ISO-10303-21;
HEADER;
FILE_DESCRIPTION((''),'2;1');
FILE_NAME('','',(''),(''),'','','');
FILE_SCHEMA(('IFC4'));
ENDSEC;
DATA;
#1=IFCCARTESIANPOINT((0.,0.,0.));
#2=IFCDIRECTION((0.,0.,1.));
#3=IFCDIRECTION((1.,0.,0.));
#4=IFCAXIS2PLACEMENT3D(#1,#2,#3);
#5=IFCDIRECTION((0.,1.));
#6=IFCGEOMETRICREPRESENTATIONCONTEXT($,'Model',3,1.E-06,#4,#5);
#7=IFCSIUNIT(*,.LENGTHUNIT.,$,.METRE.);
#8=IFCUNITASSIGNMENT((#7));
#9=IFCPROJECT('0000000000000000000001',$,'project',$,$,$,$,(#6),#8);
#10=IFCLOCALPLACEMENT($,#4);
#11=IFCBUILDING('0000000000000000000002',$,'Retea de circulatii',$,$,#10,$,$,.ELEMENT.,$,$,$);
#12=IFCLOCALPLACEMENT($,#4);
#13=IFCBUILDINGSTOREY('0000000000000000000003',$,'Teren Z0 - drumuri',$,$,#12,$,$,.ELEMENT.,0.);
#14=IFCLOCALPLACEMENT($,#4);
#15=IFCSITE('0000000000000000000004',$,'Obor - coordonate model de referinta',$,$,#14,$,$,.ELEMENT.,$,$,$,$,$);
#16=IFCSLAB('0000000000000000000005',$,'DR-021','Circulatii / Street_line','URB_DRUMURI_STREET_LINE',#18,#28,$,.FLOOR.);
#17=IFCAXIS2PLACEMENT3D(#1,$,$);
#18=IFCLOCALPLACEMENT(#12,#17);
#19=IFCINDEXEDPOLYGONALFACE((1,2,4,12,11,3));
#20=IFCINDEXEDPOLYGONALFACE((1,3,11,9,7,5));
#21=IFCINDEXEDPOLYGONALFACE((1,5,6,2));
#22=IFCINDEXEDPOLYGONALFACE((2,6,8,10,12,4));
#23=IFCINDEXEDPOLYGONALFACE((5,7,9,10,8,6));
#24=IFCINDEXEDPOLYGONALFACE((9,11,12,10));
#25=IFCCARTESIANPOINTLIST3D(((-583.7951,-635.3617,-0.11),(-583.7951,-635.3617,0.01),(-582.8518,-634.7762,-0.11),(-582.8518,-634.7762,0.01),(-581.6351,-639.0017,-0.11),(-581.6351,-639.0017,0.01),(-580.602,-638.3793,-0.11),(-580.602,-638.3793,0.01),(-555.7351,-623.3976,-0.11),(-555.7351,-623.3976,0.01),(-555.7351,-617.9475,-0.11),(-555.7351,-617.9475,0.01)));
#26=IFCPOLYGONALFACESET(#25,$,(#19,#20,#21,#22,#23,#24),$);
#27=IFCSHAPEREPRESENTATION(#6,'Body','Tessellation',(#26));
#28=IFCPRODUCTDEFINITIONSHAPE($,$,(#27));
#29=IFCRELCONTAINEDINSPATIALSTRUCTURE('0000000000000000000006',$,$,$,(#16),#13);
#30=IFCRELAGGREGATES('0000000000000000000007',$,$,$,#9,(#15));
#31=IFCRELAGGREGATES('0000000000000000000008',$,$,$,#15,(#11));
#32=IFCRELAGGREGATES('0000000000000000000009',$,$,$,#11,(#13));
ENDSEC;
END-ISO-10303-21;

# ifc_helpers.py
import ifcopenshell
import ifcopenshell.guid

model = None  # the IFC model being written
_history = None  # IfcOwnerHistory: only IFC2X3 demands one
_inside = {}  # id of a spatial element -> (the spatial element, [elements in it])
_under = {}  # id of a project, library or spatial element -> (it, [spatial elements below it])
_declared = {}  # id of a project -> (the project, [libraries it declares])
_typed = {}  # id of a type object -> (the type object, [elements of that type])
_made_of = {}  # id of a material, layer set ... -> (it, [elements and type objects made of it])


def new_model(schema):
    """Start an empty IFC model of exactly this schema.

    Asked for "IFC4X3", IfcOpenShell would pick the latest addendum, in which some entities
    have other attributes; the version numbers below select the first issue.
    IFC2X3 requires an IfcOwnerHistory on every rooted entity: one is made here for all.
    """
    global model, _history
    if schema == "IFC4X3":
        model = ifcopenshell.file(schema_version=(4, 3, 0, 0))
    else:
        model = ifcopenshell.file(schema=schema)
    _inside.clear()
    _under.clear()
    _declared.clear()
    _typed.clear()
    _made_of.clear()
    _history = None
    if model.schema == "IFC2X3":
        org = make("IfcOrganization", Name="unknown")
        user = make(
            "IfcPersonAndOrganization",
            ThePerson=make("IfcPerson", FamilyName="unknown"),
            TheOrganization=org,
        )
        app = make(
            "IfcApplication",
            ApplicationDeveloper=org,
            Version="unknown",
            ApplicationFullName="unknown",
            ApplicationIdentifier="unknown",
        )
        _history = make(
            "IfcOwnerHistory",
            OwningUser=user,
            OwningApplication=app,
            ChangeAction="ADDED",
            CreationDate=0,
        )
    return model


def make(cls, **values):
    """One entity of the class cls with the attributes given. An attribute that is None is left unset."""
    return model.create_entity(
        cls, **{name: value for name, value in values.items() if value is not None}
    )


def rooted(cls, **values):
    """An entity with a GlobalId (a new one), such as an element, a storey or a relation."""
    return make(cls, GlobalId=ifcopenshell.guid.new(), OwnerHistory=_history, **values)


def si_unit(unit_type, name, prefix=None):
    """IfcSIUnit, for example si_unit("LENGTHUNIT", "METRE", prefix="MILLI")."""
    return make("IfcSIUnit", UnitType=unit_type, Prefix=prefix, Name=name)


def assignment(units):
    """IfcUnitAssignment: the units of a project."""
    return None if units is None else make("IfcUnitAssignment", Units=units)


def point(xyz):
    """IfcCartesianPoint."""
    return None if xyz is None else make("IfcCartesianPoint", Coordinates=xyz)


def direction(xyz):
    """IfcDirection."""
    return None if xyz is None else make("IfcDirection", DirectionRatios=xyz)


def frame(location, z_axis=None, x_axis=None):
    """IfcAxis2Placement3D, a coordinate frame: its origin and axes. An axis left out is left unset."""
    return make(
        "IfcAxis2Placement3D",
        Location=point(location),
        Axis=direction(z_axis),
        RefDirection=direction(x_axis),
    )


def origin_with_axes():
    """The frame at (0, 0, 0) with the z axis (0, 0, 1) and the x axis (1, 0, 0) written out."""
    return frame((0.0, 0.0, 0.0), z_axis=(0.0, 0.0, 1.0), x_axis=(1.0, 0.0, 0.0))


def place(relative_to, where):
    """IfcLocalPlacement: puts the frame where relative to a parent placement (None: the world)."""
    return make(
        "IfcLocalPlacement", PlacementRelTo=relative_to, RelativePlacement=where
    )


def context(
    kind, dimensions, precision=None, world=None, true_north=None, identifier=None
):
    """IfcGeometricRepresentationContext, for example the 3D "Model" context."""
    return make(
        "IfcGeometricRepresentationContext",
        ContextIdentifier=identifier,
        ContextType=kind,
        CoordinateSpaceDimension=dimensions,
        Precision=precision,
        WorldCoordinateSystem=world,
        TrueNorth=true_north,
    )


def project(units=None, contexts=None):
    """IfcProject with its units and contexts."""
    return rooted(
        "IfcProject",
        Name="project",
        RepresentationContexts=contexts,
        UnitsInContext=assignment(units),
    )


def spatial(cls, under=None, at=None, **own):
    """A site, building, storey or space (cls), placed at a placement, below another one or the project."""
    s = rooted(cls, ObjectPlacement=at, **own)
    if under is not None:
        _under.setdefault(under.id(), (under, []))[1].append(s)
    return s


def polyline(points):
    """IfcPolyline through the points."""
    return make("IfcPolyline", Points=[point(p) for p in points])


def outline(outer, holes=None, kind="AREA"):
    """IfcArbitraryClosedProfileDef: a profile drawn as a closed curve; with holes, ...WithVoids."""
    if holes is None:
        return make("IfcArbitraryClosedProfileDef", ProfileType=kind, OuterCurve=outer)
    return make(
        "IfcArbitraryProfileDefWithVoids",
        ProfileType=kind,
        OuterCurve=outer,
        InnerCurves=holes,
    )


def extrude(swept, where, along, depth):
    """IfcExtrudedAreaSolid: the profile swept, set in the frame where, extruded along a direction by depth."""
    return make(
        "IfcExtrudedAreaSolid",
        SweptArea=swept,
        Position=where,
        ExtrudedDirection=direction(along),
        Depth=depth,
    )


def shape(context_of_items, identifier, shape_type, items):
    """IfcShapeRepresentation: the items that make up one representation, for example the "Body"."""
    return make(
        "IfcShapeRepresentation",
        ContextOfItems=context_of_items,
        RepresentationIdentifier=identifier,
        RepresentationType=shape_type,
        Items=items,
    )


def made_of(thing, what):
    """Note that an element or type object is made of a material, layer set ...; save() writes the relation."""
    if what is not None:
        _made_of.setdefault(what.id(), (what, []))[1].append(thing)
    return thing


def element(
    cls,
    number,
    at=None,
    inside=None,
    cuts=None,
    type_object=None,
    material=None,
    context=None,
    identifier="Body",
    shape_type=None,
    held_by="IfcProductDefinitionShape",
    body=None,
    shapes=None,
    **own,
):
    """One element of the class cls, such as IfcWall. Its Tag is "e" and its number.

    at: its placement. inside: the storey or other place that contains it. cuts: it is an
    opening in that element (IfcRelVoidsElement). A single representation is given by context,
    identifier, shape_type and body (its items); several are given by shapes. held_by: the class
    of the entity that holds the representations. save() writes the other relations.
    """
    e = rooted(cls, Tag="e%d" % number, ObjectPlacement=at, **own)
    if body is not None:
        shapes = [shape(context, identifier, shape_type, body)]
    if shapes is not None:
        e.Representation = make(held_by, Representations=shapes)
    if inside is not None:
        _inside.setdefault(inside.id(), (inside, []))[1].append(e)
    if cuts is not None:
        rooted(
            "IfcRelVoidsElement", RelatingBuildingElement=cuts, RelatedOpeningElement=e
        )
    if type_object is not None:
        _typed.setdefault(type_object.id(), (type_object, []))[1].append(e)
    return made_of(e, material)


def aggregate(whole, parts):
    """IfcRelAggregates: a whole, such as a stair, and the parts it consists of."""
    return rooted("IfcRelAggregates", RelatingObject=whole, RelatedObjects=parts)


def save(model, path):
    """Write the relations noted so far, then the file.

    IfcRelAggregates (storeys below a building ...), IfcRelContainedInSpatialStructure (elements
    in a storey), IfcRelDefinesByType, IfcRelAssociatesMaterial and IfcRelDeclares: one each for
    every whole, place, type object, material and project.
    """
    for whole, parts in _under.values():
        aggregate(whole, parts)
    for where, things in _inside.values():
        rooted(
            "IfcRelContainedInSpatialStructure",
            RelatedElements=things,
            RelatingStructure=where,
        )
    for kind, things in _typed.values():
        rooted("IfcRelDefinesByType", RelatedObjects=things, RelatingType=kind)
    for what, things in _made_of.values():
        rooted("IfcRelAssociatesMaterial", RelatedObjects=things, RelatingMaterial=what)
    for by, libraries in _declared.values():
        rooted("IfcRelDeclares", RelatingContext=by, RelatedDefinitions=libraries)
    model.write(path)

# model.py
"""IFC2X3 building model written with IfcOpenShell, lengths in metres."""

from ifc_helpers import new_model, si_unit, direction, frame, origin_with_axes, place, context, project, spatial, polyline, outline, extrude, element, save


model = new_model("IFC2X3")

# Units and contexts
model_context = context("Model", 3, precision=1e-06, world=origin_with_axes(), true_north=direction((0.0, 1.0)))
ifc_project = project(units=[si_unit("LENGTHUNIT", "METRE")], contexts=[model_context])

# Site, building, storey
site_placement = place(None, origin_with_axes())
site = spatial("IfcSite", under=ifc_project, at=site_placement, Name="Obor - coordonate model de referinta", CompositionType="ELEMENT")
building_placement = place(None, origin_with_axes())
building = spatial("IfcBuilding", under=site, at=building_placement, Name="Retea de circulatii", CompositionType="ELEMENT")
storey_placement = place(None, origin_with_axes())
storey = spatial("IfcBuildingStorey", under=building, at=storey_placement, Name="Teren Z0 - drumuri", CompositionType="ELEMENT", Elevation=0.0)

# Slab
slab_1_placement = place(None, origin_with_axes())
element("IfcSlab", 1, at=slab_1_placement, inside=storey, Name="DR-021", Description="Circulatii / Street_line", ObjectType="URB_DRUMURI_STREET_LINE", PredefinedType="FLOOR", context=model_context, shape_type="SweptSolid", body=[
    extrude(outline(polyline([(-583.7951, -635.3617), (-581.6351, -639.0017), (-580.602, -638.3793), (-555.7351, -623.3976), (-555.7351, -617.9475), (-582.8518, -634.7762), (-583.7951, -635.3617)])), frame((0.0, 0.0, -0.11), z_axis=(0.0, 0.0, 1.0), x_axis=(1.0, 0.0, 0.0)), (0.0, 0.0, 1.0), 0.12),
])

save(model, "model.ifc")
